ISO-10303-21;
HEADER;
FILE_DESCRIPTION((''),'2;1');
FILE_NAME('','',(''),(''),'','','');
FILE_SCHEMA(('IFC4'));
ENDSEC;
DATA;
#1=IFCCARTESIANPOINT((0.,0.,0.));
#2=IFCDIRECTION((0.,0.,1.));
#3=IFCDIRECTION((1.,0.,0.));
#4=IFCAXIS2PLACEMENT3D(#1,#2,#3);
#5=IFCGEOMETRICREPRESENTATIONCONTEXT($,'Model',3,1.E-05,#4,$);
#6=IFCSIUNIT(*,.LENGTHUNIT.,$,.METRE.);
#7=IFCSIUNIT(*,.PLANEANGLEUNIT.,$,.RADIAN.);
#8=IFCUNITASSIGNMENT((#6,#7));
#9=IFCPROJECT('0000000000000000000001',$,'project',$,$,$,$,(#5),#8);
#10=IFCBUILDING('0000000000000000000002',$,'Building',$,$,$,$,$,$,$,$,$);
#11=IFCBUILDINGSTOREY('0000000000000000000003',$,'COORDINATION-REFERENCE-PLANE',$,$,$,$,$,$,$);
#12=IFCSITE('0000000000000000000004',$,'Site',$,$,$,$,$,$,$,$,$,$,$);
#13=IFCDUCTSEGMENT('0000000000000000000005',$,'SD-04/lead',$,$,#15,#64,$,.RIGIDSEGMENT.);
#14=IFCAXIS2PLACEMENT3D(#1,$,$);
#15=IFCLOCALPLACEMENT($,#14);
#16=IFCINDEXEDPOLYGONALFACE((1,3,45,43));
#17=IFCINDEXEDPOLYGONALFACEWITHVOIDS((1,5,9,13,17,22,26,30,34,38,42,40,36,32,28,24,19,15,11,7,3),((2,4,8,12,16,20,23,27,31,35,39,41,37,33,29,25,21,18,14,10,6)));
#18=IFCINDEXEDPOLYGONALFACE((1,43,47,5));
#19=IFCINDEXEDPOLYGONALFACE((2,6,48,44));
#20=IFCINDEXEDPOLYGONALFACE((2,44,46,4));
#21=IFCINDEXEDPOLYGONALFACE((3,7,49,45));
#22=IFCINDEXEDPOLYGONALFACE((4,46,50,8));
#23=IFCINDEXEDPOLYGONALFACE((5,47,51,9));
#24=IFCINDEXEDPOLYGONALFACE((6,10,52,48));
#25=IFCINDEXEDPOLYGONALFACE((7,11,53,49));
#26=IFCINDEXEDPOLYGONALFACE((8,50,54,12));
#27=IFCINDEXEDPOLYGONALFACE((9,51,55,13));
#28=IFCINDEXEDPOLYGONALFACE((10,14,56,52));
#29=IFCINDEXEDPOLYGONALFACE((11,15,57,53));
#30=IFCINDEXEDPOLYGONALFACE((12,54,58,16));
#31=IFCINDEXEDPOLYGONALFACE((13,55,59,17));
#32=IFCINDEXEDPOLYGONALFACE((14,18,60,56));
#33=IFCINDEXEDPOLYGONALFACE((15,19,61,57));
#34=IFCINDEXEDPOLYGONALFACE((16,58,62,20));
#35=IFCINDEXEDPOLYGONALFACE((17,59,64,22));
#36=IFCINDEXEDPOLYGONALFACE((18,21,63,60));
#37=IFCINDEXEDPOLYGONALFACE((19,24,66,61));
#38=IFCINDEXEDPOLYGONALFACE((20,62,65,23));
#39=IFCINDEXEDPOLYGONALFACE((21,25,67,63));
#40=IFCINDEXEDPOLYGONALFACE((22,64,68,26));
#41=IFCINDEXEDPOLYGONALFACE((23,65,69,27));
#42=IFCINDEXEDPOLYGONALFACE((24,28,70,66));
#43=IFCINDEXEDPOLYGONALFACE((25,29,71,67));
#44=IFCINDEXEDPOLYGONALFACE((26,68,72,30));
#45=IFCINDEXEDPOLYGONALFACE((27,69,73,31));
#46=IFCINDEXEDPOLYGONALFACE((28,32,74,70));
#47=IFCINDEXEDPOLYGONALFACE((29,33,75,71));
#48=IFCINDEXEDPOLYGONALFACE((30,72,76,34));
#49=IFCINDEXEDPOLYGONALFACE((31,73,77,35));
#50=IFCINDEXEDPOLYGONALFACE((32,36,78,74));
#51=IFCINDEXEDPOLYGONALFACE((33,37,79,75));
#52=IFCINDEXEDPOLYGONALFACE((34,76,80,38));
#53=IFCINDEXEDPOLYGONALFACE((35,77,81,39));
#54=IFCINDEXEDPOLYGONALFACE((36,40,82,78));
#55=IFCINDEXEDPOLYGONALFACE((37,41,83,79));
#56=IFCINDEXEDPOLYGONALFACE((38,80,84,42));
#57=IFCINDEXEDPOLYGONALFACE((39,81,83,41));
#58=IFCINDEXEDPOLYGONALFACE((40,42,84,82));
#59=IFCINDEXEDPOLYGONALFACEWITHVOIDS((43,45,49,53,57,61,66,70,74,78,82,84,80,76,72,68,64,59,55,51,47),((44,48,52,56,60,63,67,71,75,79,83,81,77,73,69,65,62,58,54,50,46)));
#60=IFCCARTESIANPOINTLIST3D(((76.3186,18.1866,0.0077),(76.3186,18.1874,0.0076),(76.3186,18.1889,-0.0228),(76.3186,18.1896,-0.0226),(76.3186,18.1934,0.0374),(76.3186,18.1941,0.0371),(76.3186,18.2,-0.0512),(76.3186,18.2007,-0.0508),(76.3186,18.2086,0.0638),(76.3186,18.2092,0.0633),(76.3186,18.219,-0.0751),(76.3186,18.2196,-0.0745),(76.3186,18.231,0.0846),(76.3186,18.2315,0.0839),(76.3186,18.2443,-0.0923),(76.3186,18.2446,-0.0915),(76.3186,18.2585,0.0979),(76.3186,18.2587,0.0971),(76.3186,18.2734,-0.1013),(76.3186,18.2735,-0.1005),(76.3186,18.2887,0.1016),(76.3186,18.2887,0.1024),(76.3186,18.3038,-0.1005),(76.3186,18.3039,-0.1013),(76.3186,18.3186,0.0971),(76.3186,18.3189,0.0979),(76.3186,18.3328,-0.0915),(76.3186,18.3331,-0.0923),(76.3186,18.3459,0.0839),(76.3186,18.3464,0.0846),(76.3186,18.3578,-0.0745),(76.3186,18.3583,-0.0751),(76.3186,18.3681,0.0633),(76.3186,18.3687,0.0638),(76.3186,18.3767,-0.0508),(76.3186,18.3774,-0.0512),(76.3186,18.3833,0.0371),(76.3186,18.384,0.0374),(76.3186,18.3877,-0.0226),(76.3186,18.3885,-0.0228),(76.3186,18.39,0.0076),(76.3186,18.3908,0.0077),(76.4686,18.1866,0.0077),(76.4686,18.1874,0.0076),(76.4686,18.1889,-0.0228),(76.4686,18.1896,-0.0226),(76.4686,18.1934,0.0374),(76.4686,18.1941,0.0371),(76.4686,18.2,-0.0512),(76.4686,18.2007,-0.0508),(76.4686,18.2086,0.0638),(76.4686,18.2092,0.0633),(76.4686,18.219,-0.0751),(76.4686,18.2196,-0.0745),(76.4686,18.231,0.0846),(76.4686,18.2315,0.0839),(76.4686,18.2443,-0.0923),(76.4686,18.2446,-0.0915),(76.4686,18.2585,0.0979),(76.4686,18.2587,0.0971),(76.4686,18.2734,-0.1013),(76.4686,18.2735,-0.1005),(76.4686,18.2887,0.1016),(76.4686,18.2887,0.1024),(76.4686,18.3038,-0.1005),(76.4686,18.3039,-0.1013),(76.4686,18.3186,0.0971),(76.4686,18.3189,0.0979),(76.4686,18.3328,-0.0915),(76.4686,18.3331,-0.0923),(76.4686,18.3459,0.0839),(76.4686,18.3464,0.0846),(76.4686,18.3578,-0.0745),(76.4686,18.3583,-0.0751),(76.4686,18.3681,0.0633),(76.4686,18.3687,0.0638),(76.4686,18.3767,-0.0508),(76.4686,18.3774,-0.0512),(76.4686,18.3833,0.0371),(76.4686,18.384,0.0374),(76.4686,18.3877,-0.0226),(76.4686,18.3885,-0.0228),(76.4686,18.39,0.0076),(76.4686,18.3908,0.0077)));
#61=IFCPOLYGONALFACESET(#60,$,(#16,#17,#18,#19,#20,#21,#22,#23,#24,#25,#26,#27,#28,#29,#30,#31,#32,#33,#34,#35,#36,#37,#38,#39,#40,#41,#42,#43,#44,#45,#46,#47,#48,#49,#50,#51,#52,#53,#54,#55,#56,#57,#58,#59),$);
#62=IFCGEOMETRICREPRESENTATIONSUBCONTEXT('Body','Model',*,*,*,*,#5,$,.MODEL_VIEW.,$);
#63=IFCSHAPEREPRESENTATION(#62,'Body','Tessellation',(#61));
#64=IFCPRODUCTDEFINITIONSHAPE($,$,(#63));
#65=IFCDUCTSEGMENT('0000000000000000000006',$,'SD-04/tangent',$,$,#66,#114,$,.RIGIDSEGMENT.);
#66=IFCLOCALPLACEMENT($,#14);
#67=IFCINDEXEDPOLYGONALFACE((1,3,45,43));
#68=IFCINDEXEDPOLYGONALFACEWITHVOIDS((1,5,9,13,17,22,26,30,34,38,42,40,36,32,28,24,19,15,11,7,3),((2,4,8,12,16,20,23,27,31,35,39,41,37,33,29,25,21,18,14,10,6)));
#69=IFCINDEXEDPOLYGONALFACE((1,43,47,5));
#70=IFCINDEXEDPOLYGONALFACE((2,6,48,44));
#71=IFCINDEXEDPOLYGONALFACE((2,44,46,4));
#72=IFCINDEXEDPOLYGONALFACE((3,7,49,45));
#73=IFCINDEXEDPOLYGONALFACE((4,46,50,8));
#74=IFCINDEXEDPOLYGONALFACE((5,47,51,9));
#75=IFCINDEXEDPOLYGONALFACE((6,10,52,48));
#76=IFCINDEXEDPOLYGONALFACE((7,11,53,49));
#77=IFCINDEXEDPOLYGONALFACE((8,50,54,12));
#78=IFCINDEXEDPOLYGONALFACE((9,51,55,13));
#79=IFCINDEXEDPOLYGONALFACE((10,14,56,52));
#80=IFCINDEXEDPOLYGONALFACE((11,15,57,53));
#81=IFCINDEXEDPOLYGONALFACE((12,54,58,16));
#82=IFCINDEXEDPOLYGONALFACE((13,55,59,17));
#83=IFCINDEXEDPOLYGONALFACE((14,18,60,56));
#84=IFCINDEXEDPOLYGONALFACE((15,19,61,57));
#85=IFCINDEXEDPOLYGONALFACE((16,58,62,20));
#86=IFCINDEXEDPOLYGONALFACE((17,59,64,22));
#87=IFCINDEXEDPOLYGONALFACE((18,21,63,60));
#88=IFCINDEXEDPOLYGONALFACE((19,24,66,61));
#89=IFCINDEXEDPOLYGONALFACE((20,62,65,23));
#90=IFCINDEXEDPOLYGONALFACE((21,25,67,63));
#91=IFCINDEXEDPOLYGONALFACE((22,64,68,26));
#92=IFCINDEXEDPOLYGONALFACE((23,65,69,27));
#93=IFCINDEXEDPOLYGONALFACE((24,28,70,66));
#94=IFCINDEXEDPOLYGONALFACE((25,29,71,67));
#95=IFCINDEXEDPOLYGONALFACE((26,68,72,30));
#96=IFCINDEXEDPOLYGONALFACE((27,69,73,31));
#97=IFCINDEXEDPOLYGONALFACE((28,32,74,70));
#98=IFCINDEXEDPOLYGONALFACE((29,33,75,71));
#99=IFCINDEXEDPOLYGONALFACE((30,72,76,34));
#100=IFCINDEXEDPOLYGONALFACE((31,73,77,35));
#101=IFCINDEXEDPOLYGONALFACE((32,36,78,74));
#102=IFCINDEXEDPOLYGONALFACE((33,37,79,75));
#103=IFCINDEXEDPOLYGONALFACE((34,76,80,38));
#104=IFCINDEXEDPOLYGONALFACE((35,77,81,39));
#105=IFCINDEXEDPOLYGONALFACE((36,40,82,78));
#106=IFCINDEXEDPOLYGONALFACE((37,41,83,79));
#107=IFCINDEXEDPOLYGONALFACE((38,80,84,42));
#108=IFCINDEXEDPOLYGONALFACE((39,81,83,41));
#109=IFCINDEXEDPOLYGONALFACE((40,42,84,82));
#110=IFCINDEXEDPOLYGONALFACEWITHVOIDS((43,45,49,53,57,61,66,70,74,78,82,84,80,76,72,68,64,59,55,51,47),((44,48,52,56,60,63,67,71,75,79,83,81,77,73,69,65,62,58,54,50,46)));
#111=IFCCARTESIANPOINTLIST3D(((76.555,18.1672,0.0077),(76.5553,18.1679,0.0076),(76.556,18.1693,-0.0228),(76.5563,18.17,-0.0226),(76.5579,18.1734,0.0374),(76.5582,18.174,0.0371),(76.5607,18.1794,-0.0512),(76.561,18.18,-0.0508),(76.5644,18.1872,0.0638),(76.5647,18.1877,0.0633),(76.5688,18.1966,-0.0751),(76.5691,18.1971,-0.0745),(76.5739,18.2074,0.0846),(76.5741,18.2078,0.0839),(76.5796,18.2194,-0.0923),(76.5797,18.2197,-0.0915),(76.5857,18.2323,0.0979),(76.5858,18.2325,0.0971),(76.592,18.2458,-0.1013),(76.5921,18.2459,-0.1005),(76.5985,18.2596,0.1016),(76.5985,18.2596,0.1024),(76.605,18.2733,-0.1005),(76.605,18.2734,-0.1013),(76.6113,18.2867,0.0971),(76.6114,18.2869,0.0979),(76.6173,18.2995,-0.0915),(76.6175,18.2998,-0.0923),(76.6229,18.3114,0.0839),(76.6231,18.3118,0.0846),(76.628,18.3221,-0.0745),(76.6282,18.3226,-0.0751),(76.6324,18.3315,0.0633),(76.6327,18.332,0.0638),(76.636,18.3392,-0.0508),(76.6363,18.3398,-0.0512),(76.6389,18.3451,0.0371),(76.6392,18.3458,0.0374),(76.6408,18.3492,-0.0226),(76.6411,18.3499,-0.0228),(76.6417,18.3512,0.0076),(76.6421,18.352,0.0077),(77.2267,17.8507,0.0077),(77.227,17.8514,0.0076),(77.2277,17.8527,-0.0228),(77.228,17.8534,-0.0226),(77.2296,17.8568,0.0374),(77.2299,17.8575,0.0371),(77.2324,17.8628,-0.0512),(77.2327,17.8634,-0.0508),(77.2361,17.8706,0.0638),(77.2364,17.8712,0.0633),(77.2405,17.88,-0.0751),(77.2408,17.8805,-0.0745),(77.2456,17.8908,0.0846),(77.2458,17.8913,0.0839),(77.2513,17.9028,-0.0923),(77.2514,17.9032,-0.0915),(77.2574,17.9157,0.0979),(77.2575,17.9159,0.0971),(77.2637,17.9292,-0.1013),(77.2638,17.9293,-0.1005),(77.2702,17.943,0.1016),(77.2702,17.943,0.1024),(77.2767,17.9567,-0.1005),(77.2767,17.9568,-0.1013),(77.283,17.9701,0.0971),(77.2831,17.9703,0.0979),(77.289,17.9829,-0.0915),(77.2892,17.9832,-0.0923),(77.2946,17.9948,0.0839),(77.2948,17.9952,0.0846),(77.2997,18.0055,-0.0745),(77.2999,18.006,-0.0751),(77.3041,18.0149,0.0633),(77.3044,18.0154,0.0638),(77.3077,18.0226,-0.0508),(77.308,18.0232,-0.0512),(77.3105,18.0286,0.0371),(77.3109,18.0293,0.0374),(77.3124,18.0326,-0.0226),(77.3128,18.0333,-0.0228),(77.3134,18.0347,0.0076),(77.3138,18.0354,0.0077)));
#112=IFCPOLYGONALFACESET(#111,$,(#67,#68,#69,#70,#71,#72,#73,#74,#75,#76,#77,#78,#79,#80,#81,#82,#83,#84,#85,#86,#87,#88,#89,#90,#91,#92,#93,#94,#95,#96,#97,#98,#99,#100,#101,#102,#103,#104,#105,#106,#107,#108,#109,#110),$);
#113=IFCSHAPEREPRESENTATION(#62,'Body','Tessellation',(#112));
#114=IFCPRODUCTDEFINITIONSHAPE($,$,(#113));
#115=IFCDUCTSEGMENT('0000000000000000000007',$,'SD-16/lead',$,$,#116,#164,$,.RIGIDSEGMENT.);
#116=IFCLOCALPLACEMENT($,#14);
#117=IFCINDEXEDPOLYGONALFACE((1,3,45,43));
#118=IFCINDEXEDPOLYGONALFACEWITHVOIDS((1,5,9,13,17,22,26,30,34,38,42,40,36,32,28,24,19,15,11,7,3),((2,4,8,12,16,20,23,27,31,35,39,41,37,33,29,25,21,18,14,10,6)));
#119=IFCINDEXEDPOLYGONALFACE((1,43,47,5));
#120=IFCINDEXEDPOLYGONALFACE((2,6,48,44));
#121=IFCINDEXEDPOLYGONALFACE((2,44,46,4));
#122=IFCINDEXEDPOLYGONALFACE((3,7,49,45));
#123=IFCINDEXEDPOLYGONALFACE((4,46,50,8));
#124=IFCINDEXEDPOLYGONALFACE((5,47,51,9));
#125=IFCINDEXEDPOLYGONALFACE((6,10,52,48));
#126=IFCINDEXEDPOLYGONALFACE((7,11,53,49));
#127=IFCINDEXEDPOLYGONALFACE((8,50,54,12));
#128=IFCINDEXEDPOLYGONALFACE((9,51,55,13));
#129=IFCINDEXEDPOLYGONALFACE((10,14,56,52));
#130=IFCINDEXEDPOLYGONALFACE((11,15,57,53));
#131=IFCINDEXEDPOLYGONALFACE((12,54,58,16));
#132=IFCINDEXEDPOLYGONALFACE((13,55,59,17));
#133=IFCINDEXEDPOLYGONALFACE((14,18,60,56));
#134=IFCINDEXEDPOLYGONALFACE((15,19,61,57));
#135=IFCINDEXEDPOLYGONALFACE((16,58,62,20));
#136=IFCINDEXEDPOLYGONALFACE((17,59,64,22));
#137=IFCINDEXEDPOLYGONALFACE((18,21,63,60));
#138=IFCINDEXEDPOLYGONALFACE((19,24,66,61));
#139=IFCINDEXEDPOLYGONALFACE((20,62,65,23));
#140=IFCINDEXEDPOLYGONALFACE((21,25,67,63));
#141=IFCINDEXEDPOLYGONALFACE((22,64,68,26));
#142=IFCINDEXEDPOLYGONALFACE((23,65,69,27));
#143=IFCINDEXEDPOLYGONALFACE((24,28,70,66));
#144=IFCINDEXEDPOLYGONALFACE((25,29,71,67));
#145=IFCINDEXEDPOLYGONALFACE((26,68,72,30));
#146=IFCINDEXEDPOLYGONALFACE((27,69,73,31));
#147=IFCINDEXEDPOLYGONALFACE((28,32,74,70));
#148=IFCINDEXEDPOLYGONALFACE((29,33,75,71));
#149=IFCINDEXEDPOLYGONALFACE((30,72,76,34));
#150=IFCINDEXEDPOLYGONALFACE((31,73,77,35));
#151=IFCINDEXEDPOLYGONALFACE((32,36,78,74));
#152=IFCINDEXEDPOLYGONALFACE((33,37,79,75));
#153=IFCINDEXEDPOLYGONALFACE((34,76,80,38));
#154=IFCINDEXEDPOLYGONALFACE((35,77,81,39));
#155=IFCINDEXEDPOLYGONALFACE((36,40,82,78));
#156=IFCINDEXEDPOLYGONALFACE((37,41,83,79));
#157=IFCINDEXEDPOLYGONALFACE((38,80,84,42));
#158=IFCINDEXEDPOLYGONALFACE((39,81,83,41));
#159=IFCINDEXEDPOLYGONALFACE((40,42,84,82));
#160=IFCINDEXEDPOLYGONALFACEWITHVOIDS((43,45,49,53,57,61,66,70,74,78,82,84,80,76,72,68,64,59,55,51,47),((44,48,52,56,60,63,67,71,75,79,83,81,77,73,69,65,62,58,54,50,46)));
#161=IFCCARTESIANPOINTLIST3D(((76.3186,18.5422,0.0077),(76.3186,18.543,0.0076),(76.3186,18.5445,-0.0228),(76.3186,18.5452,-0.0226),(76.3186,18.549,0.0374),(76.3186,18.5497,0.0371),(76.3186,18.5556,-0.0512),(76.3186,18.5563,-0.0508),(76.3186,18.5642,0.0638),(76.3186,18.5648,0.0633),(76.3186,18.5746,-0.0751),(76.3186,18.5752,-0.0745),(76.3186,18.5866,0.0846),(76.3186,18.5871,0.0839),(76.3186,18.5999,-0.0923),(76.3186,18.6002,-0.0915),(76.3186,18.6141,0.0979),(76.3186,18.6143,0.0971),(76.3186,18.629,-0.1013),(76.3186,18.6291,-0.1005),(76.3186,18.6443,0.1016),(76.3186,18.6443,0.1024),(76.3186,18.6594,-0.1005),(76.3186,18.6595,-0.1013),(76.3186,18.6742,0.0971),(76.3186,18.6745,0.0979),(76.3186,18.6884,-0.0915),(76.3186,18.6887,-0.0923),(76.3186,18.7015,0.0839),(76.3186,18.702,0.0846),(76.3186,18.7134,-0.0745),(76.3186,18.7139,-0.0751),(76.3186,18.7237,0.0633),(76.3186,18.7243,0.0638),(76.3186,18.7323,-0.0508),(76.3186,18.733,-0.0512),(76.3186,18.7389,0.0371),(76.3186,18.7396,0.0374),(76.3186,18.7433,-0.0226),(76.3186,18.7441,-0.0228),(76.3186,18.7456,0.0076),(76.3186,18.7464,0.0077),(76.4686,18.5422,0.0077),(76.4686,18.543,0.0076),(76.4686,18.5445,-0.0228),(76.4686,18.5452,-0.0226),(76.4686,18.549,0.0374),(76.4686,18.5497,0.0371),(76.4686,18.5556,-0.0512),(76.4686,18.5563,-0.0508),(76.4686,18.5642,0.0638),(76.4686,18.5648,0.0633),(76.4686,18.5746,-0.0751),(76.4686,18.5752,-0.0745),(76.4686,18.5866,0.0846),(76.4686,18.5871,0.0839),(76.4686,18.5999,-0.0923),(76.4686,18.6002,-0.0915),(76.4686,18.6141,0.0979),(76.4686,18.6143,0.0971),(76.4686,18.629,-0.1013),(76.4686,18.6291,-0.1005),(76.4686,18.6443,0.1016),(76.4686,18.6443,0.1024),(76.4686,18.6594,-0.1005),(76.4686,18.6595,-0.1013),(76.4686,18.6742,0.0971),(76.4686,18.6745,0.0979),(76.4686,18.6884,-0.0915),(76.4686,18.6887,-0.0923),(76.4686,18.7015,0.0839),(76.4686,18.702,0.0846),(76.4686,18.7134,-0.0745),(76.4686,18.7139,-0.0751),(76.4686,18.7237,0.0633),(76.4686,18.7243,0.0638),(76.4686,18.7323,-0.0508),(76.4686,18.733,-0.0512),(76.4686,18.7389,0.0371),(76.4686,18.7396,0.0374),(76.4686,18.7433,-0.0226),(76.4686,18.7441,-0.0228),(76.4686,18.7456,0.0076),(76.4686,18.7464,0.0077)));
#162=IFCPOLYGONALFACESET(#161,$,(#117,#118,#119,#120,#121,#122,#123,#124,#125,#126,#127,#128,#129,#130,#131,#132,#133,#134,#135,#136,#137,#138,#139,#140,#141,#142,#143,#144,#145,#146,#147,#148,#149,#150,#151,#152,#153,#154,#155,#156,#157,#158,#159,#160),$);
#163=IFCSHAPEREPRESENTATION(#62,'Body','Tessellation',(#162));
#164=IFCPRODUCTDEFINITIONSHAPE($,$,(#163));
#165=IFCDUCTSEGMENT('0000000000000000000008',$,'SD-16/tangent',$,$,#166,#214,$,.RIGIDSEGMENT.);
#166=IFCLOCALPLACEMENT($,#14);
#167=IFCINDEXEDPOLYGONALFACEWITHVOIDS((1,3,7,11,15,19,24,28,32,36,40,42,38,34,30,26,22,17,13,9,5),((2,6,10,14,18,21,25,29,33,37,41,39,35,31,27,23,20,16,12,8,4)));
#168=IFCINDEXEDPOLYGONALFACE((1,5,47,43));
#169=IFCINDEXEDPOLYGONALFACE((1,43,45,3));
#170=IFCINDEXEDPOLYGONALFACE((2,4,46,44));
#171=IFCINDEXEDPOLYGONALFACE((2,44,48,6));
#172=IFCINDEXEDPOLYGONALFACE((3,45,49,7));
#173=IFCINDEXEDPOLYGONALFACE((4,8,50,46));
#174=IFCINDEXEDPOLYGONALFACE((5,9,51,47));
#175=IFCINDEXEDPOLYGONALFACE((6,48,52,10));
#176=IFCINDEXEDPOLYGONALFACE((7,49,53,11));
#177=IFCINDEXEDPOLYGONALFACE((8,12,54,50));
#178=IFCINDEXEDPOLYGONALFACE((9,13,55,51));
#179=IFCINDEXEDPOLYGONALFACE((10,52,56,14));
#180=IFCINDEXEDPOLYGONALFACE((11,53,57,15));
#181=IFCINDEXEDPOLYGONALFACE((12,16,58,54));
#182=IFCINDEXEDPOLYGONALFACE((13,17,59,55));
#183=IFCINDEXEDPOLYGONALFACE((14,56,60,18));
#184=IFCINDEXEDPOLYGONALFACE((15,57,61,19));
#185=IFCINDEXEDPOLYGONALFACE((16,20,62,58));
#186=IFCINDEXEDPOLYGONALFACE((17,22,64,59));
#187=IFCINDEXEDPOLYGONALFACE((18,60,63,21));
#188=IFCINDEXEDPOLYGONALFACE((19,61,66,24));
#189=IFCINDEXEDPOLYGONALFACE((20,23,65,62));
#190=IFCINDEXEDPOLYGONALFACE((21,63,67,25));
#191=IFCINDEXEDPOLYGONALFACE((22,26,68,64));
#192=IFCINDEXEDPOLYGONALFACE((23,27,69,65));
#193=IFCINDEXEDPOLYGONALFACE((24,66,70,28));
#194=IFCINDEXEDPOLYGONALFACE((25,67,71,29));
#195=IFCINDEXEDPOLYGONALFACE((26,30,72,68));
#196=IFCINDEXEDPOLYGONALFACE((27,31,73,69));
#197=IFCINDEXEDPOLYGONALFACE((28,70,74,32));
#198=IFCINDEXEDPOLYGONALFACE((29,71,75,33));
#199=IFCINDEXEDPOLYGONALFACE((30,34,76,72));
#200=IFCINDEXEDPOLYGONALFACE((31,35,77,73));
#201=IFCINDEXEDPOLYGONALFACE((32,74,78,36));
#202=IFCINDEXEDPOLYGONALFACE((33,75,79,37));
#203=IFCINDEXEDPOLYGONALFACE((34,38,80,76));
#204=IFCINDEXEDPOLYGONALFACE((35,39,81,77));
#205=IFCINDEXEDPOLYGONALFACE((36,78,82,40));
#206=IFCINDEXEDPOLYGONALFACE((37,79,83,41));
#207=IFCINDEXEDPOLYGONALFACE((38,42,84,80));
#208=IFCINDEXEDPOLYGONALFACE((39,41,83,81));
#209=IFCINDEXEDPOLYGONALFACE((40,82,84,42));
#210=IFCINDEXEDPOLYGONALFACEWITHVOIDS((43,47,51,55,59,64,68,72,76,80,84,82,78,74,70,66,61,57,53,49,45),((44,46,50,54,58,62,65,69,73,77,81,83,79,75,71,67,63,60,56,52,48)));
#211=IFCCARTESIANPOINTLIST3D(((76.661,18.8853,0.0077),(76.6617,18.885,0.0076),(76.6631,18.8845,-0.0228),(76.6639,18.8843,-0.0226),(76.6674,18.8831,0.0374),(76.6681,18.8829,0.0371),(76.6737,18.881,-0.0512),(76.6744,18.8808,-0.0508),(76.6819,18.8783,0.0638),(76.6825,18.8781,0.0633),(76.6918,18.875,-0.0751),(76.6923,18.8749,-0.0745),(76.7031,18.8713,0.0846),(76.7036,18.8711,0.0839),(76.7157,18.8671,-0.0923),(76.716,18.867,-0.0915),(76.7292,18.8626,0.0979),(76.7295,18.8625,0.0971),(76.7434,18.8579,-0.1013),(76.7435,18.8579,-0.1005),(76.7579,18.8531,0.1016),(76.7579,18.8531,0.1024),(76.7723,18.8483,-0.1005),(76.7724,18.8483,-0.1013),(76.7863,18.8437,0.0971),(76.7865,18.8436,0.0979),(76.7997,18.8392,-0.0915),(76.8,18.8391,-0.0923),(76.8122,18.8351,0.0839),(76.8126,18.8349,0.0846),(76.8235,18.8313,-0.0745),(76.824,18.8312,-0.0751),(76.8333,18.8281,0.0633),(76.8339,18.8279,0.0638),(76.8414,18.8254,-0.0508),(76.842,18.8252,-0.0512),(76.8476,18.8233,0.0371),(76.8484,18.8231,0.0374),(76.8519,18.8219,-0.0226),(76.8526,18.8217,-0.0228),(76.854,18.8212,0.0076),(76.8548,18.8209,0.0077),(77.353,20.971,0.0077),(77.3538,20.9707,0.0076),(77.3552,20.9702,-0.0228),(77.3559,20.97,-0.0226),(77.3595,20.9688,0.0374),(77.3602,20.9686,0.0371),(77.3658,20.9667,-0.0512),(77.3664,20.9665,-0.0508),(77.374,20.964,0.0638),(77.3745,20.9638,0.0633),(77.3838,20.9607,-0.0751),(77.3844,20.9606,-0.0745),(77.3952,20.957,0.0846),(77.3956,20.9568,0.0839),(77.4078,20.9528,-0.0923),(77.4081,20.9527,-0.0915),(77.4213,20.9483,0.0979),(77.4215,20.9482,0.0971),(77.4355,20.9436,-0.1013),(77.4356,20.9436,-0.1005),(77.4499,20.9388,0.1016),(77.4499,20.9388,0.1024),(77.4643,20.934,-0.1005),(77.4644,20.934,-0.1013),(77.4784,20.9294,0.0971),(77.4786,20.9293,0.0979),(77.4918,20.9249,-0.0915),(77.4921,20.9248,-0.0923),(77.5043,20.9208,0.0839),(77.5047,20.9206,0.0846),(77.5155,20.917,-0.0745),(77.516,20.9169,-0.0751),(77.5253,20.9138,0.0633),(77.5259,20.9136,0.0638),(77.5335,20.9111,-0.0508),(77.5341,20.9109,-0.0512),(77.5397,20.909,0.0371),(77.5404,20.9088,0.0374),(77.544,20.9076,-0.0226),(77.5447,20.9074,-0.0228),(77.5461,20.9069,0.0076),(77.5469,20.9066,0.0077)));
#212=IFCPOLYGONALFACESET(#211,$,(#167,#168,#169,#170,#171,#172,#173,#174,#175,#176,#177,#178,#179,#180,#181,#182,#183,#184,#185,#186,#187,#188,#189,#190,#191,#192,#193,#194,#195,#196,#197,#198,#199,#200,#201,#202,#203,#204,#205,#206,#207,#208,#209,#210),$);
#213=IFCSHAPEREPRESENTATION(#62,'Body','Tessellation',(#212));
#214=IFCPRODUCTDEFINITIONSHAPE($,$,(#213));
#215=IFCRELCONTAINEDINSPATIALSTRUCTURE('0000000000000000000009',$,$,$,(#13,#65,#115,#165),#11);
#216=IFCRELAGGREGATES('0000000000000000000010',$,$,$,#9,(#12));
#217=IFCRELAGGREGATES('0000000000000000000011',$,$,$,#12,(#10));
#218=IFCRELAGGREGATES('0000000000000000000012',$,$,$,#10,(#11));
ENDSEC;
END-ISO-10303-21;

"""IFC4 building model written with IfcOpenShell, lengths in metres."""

from ifc_helpers import new_model, si_unit, frame, origin_with_axes, place, context, subcontext, project, spatial, hollow_circle, extrude, element, save


model = new_model("IFC4")

# Units and contexts
model_context_1 = context("Model", 3, precision=1e-05, world=origin_with_axes())
body_context_1 = subcontext(model_context_1, "Body", "Model", "MODEL_VIEW")
ifc_project = project(units=[si_unit("LENGTHUNIT", "METRE"), si_unit("PLANEANGLEUNIT", "RADIAN")], contexts=[model_context_1])

# Site, building, storey
site = spatial("IfcSite", under=ifc_project, Name="Site")
building = spatial("IfcBuilding", under=site, Name="Building")
storey = spatial("IfcBuildingStorey", under=building, Name="COORDINATION-REFERENCE-PLANE")

# Duct segment
duct_segment_1_placement = place(None, frame((76.3186, 18.2887, 0.0), z_axis=(1.0, 0.0, 0.0), x_axis=(0.0, 0.0, 1.0)))
element("IfcDuctSegment", 1, at=duct_segment_1_placement, inside=storey, Name="SD-04/lead", PredefinedType="RIGIDSEGMENT", context=body_context_1, shape_type="SweptSolid", body=[
    extrude(hollow_circle(Radius=0.1024, WallThickness=0.0008), origin_with_axes(), (0.0, 0.0, 1.0), 0.15),
])

# Duct segment
duct_segment_2_placement = place(None, frame((76.5985, 18.2596, 0.0), z_axis=(0.904569, -0.426327, 0.0), x_axis=(0.0, 0.0, 1.0)))
element("IfcDuctSegment", 2, at=duct_segment_2_placement, inside=storey, Name="SD-04/tangent", PredefinedType="RIGIDSEGMENT", context=body_context_1, shape_type="SweptSolid", body=[
    extrude(hollow_circle(Radius=0.1024, WallThickness=0.0008), origin_with_axes(), (0.0, 0.0, 1.0), 0.7425),
])

# Duct segment
duct_segment_3_placement = place(None, frame((76.3186, 18.6443, 0.0), z_axis=(1.0, 0.0, 0.0), x_axis=(0.0, 0.0, 1.0)))
element("IfcDuctSegment", 3, at=duct_segment_3_placement, inside=storey, Name="SD-16/lead", PredefinedType="RIGIDSEGMENT", context=body_context_1, shape_type="SweptSolid", body=[
    extrude(hollow_circle(Radius=0.1024, WallThickness=0.0008), origin_with_axes(), (0.0, 0.0, 1.0), 0.15),
])

# Duct segment
duct_segment_4_placement = place(None, frame((76.7579, 18.8531, 0.0), z_axis=(0.314929, 0.949115, 0.0), x_axis=(0.0, 0.0, 1.0)))
element("IfcDuctSegment", 4, at=duct_segment_4_placement, inside=storey, Name="SD-16/tangent", PredefinedType="RIGIDSEGMENT", context=body_context_1, shape_type="SweptSolid", body=[
    extrude(hollow_circle(Radius=0.1024, WallThickness=0.0008), origin_with_axes(), (0.0, 0.0, 1.0), 2.1975),
])

save(model, "model.ifc")
